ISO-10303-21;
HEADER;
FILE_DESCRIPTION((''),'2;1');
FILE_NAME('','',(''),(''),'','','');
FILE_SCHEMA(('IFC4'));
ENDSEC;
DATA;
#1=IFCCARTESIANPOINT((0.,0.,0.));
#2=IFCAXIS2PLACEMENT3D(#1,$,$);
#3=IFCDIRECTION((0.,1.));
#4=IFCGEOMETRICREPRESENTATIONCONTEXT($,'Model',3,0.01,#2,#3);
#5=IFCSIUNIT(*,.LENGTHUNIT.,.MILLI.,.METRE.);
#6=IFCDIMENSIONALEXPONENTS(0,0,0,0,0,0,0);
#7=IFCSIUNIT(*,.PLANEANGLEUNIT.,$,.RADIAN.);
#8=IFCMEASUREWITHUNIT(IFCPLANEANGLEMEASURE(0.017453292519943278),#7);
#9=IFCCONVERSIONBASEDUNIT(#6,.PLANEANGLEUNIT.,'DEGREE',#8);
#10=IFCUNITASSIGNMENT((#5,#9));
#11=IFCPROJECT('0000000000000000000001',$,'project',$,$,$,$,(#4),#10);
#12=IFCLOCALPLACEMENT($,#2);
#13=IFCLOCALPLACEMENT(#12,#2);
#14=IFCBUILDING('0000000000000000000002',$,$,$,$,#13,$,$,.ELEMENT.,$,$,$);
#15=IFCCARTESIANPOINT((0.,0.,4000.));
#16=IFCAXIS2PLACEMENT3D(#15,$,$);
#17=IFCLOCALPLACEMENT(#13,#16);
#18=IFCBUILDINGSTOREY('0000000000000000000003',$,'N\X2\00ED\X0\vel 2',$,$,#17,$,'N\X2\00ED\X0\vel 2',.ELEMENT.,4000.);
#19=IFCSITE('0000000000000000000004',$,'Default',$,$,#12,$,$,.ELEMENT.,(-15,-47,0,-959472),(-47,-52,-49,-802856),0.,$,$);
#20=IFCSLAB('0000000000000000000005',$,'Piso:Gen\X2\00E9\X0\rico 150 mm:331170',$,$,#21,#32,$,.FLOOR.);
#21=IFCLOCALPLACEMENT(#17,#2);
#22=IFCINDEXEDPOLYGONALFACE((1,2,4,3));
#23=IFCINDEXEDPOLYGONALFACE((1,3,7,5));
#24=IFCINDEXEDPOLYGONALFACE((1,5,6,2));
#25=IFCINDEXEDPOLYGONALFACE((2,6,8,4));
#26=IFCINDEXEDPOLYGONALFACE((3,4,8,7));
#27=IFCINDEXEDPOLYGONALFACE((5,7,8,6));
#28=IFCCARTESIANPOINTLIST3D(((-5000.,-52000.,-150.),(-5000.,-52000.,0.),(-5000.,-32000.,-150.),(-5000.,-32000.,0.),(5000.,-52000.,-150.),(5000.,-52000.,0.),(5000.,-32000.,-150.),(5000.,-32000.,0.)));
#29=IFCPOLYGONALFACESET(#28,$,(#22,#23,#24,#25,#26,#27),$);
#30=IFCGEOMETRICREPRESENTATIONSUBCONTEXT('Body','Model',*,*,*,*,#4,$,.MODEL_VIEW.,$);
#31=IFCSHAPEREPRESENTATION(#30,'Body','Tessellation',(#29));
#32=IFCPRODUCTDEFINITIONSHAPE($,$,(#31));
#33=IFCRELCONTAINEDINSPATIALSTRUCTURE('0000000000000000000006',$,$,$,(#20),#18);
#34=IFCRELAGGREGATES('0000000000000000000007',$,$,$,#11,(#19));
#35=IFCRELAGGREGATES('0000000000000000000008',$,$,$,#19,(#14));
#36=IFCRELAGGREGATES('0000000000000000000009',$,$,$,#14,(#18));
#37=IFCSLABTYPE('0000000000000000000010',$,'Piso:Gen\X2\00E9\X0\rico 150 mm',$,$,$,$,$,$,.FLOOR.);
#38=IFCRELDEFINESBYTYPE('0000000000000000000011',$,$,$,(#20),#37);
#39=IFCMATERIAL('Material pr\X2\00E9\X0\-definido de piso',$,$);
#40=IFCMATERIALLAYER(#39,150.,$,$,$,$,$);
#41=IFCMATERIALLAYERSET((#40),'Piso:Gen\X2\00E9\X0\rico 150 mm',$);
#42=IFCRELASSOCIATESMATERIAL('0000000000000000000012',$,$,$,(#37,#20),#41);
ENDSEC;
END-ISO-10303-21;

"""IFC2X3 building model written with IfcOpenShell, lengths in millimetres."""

from ifc_helpers import new_model, entity, si_unit, converted_unit, direction, frame, frame_2d, origin, place, context, subcontext, project, spatial, rectangle, extrude, material, layer, layer_set, layer_usage, type_object, element, save


model = new_model("IFC2X3")

# Units and contexts
model_context = context("Model", 3, precision=0.01, world=origin(), true_north=direction((0.0, 1.0)))
body_context = subcontext(model_context, "Body", "Model", "MODEL_VIEW")
ifc_project = project(units=[si_unit("LENGTHUNIT", "METRE", prefix="MILLI"), converted_unit("PLANEANGLEUNIT", "DEGREE", entity("IfcPlaneAngleMeasure", 0.017453292519943278), si_unit("PLANEANGLEUNIT", "RADIAN"), dimensions=[0, 0, 0, 0, 0, 0, 0])], contexts=[model_context])

# Site, building, storey
site_placement = place(None, origin())
site = spatial("IfcSite", under=ifc_project, at=site_placement, Name="Default", CompositionType="ELEMENT", RefLatitude=(-15, -47, 0, -959472), RefLongitude=(-47, -52, -49, -802856), RefElevation=0.0)
building_placement = place(site_placement, origin())
building = spatial("IfcBuilding", under=site, at=building_placement, CompositionType="ELEMENT")
storey_placement = place(building_placement, frame((0.0, 0.0, 4000.0)))
storey = spatial("IfcBuildingStorey", under=building, at=storey_placement, Name="Nível 2", LongName="Nível 2", CompositionType="ELEMENT", Elevation=4000.0)

# Slab
ifc_material = material(Name="Material pré-definido de piso")
ifc_layer = layer(ifc_material, 150.0)
ifc_layer_set = layer_set([ifc_layer], Name="Piso:Genérico 150 mm")
ifc_layer_usage = layer_usage(ifc_layer_set, "AXIS3", "POSITIVE", 0.0)
slab_type = type_object("IfcSlabType", Name="Piso:Genérico 150 mm", PredefinedType="FLOOR", material=ifc_layer_set)
slab_placement = place(storey_placement, origin())
element("IfcSlab", 1, at=slab_placement, inside=storey, type_object=slab_type, material=ifc_layer_usage, Name="Piso:Genérico 150 mm:331170", PredefinedType="FLOOR", context=body_context, shape_type="SweptSolid", body=[
    extrude(rectangle(XDim=20000.0, YDim=10000.0, at=frame_2d((0.0, 0.0), x_axis=(1.0, 0.0))), frame((0.0, -42000.0, 0.0), z_axis=(0.0, 0.0, -1.0), x_axis=(0.0, 1.0, 0.0)), (0.0, 0.0, 1.0), 150.0),
])

save(model, "model.ifc")
